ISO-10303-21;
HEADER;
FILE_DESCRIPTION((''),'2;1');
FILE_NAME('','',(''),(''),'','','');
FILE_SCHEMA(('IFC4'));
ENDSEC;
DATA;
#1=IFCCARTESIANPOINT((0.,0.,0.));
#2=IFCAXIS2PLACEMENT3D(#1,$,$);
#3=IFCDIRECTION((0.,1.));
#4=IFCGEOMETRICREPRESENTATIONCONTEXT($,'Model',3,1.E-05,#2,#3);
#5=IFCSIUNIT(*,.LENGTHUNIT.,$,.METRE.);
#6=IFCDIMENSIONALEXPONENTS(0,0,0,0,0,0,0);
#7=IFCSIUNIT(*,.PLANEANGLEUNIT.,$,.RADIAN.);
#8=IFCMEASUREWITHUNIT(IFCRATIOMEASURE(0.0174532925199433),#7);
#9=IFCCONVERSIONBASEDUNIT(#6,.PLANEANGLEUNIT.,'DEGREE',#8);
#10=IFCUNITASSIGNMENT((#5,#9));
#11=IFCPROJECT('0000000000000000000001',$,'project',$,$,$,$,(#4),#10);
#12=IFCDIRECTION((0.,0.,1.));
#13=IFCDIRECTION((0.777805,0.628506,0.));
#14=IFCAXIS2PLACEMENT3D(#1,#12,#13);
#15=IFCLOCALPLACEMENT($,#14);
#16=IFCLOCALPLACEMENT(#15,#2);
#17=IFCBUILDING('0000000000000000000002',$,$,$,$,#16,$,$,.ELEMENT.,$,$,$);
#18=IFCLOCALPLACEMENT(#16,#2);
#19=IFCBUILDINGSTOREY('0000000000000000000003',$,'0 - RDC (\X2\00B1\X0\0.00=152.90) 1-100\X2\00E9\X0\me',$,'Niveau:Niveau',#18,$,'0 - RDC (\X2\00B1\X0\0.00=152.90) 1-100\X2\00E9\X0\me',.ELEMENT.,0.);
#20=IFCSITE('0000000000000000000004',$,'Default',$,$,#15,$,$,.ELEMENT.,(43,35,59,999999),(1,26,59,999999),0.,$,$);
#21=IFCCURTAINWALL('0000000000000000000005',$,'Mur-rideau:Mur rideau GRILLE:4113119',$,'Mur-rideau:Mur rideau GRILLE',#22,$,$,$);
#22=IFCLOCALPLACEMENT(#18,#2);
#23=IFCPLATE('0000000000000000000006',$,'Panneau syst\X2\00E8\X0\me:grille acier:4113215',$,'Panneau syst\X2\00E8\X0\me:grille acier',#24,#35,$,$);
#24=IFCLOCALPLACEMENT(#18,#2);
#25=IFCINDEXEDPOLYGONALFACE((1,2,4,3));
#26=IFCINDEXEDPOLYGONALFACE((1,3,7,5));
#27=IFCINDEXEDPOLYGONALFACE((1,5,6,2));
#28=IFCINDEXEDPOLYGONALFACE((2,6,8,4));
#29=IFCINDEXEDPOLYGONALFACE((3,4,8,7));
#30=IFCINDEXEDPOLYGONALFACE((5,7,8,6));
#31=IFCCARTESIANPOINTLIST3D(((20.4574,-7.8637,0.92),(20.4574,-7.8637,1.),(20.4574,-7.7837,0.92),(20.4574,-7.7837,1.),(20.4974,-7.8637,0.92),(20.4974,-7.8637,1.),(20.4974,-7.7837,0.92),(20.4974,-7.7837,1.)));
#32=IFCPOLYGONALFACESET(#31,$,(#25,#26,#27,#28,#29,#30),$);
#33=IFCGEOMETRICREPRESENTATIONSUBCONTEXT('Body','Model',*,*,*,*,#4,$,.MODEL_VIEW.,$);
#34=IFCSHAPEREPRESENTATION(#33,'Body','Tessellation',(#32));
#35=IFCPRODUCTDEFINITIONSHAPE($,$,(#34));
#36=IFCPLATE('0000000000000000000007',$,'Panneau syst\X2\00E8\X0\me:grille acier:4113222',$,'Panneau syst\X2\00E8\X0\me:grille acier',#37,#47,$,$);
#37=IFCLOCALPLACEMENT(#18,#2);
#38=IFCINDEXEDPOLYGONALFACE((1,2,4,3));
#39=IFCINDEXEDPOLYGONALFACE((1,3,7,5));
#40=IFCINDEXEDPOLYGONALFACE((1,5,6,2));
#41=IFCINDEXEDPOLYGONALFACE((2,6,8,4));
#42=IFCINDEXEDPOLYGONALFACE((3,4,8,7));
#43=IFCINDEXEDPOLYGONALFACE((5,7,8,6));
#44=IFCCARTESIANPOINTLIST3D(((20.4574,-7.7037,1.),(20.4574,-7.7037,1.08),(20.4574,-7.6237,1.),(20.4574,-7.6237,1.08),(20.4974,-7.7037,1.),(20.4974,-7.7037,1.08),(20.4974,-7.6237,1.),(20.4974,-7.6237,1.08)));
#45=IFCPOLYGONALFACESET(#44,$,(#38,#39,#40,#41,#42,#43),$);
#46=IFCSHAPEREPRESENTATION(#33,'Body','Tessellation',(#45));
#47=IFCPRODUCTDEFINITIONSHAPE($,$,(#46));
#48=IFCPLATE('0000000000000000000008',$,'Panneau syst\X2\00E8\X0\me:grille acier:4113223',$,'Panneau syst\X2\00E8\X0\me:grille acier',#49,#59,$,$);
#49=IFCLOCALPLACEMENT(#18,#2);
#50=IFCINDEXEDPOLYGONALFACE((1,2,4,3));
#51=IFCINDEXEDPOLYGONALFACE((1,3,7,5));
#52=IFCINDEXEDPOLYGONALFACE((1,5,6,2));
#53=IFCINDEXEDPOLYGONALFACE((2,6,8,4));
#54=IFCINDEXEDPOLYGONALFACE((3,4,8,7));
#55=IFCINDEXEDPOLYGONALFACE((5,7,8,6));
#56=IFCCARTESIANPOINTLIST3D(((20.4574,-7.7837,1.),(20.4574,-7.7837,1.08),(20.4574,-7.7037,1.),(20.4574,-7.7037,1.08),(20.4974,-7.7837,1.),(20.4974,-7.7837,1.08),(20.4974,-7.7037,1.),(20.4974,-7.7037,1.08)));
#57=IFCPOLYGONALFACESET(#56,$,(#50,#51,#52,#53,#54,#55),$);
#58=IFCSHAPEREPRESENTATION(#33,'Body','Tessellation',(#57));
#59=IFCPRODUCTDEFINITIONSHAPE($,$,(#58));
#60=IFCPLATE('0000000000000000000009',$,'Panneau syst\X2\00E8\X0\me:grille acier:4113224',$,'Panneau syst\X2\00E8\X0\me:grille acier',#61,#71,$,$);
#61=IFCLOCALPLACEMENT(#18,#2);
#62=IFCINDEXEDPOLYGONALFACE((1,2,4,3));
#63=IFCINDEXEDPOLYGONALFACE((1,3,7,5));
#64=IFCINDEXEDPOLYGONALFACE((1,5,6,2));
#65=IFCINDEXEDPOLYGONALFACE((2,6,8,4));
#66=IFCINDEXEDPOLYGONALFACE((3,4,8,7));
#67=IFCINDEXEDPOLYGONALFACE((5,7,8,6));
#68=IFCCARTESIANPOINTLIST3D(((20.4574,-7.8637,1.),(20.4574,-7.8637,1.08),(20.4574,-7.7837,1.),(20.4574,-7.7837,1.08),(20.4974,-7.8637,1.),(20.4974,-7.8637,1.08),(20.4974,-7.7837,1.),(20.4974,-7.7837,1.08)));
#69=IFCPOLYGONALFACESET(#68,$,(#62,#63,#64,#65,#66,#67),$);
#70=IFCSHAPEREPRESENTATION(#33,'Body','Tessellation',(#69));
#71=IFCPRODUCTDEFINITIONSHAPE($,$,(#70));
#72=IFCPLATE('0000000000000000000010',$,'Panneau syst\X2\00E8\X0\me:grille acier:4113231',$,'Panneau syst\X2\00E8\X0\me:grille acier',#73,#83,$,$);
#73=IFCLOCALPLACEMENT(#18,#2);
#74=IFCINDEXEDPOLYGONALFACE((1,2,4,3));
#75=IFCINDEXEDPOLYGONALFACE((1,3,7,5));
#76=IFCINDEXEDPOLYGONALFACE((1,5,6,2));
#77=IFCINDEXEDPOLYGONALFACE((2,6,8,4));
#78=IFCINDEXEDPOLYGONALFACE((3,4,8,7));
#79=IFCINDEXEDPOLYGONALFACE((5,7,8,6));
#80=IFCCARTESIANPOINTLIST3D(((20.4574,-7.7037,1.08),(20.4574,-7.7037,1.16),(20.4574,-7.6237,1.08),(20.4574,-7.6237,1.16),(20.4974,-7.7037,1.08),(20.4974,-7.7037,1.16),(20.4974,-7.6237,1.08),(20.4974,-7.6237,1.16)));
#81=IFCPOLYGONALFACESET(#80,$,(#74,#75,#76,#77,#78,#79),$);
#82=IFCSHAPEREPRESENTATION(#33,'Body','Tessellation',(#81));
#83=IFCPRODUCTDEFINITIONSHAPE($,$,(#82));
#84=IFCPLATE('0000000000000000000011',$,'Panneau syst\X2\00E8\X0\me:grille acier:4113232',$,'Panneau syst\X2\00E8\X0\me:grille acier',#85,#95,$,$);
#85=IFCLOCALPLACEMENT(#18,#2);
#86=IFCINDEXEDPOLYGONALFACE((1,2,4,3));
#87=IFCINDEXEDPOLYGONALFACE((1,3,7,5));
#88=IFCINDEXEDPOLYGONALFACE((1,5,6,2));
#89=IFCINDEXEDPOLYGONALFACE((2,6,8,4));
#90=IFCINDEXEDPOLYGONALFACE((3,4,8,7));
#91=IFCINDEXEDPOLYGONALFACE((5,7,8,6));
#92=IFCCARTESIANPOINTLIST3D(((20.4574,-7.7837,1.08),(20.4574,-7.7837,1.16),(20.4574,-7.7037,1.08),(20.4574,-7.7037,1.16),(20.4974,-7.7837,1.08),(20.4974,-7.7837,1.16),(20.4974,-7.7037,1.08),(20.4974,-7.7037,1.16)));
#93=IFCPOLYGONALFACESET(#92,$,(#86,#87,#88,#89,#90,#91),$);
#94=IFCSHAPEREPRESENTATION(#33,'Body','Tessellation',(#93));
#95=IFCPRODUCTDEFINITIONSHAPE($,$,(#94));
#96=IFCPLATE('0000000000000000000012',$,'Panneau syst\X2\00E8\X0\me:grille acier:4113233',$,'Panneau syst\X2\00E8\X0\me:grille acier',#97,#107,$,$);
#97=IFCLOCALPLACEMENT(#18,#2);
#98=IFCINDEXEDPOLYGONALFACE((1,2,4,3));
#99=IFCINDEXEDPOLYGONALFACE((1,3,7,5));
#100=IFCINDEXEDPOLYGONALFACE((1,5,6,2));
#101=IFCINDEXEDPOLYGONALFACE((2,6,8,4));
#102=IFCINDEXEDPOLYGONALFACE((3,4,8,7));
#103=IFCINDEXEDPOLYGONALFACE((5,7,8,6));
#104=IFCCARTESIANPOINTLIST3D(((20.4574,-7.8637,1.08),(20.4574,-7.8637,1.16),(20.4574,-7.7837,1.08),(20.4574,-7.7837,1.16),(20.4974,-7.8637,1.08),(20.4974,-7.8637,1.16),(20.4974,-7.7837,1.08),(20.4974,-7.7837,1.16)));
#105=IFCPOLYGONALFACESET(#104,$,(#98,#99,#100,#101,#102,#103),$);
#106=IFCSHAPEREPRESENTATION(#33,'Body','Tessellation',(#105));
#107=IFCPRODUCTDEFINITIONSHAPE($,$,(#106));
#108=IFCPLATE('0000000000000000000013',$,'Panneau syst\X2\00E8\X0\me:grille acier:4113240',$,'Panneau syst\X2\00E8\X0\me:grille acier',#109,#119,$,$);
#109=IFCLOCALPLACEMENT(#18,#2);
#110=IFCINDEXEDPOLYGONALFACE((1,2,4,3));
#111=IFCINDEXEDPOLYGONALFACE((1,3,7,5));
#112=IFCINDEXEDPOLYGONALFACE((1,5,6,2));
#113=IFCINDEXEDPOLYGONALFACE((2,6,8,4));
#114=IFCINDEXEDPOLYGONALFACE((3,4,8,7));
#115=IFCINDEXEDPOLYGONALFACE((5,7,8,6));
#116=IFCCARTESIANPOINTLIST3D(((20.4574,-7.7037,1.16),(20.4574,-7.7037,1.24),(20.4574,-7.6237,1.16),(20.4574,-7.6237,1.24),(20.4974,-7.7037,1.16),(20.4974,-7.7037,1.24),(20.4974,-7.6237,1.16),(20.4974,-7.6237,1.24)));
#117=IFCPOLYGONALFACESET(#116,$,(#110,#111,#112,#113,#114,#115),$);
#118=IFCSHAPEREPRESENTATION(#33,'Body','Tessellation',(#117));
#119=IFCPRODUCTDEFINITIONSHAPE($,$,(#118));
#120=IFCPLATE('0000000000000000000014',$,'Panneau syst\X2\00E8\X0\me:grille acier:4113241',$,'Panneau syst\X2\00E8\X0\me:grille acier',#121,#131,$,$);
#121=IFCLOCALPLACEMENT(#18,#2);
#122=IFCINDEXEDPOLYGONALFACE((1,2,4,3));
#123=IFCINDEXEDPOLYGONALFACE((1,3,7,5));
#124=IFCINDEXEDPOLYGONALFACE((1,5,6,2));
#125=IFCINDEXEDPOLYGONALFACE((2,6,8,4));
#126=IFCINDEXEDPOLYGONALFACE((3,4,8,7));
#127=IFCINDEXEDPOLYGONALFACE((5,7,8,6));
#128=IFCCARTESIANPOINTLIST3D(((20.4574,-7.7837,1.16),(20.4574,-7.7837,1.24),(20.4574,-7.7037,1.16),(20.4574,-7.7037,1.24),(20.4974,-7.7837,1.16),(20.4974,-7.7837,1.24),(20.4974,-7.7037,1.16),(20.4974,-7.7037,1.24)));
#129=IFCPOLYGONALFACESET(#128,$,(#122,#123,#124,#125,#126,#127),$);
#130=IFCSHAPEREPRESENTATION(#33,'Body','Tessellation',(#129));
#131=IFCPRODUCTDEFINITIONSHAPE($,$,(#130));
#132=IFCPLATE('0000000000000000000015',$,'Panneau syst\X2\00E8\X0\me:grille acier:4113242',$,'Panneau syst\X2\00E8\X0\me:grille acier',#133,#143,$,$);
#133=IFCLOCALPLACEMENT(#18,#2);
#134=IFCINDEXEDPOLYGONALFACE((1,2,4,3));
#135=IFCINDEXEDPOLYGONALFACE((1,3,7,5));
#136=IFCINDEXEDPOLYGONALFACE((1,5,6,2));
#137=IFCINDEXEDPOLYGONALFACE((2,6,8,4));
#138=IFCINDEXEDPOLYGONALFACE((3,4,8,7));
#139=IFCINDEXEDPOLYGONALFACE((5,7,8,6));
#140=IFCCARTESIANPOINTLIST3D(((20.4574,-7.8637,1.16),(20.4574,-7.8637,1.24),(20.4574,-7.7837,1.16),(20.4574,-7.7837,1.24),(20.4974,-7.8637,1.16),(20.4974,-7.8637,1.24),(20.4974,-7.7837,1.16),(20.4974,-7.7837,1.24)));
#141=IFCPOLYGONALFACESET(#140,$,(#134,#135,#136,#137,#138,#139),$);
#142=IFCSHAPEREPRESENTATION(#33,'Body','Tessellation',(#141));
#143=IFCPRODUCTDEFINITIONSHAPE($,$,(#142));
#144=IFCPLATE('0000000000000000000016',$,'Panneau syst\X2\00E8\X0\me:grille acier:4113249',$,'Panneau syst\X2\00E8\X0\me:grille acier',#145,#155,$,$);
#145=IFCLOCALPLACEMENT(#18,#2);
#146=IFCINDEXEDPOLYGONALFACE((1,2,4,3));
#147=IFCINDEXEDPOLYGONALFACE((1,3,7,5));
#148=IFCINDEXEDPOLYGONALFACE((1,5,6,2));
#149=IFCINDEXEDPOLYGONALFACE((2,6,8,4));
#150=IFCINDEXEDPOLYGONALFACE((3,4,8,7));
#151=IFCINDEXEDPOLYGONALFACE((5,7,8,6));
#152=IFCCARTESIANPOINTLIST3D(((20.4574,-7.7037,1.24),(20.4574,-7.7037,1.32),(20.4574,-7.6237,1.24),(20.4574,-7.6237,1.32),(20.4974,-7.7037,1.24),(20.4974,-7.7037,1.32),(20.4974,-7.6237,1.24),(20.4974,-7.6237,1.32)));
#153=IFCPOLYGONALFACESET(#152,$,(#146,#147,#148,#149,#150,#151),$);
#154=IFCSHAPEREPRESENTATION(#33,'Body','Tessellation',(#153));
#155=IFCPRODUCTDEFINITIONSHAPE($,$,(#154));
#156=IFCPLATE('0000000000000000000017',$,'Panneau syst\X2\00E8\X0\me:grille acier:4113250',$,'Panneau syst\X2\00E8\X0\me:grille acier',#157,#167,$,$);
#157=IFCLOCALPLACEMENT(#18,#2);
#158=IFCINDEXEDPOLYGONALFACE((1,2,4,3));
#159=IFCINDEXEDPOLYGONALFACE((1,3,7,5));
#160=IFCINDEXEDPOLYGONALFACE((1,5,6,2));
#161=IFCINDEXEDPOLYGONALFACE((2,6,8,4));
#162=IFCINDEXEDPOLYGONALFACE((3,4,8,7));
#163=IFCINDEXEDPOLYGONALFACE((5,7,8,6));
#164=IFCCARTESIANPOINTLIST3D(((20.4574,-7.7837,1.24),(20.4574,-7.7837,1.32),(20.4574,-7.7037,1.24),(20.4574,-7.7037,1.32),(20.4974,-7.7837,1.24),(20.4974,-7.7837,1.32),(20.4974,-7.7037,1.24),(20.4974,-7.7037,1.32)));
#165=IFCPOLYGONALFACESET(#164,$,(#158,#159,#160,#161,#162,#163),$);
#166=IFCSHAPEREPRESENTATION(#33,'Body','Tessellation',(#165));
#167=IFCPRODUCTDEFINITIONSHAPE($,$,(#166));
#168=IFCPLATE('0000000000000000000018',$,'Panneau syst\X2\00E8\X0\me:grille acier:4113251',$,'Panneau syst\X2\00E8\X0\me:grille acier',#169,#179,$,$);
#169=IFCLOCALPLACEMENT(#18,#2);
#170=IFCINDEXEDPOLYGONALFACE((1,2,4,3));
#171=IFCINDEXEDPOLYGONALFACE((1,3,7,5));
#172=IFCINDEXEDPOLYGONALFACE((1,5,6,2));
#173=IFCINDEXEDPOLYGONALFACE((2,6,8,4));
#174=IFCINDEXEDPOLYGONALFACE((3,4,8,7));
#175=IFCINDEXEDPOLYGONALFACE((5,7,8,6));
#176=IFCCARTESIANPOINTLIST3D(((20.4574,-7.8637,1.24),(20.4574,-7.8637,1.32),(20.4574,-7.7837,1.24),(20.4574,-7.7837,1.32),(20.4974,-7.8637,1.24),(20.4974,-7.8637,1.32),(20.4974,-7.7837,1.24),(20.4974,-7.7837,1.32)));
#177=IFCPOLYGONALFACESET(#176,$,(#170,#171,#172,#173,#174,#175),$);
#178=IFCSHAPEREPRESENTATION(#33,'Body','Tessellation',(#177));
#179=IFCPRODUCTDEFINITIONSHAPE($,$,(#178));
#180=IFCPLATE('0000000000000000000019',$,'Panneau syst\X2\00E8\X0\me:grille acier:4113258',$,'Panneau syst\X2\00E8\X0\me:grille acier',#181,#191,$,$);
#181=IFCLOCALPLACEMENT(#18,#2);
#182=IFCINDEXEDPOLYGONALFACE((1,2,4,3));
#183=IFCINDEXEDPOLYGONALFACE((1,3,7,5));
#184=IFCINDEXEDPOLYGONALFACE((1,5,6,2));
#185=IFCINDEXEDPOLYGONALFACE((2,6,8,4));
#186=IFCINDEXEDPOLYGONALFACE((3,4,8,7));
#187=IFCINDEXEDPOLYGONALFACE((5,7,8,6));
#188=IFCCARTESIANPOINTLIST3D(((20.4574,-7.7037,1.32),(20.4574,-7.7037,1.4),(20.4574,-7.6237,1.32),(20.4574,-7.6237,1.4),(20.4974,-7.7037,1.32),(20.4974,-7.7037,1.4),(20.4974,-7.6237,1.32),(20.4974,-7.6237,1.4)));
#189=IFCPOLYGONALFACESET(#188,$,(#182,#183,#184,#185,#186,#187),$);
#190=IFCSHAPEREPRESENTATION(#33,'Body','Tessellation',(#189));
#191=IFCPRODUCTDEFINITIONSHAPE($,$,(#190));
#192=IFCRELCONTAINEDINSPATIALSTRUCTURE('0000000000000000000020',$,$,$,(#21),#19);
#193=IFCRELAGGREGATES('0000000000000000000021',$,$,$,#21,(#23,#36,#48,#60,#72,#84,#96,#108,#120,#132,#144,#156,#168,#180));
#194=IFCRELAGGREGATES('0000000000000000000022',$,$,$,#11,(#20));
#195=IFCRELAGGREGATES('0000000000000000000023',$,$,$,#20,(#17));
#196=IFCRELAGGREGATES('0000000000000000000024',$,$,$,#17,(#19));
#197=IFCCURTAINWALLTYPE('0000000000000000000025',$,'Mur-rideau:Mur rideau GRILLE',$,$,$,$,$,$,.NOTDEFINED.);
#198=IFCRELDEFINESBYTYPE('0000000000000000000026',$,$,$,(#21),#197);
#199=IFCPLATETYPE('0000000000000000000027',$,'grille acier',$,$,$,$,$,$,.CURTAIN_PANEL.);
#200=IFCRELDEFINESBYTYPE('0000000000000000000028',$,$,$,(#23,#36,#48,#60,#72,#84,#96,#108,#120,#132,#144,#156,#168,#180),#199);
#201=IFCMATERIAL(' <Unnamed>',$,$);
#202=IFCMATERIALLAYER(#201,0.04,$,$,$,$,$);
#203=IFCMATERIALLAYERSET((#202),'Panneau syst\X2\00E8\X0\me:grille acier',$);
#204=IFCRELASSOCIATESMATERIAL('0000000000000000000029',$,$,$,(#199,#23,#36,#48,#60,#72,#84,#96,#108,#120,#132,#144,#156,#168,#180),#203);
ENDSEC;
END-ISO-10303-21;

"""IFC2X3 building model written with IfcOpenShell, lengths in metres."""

from ifc_helpers import new_model, entity, si_unit, converted_unit, direction, frame, origin, origin_2d_with_axis, place, context, subcontext, project, spatial, rectangle, extrude, source, transform, mapped, material, layer, layer_set, layer_usage, type_object, type_shapes, element, aggregate, save


model = new_model("IFC2X3")

# Units and contexts
model_context = context("Model", 3, precision=1e-05, world=origin(), true_north=direction((0.0, 1.0)))
body_context = subcontext(model_context, "Body", "Model", "MODEL_VIEW")
ifc_project = project(units=[si_unit("LENGTHUNIT", "METRE"), converted_unit("PLANEANGLEUNIT", "DEGREE", entity("IfcRatioMeasure", 0.0174532925199433), si_unit("PLANEANGLEUNIT", "RADIAN"), dimensions=[0, 0, 0, 0, 0, 0, 0])], contexts=[model_context])

# Site, building, storey
site_placement = place(None, frame((0.0, 0.0, 0.0), z_axis=(0.0, 0.0, 1.0), x_axis=(0.777805, 0.628506, 0.0)))
site = spatial("IfcSite", under=ifc_project, at=site_placement, Name="Default", CompositionType="ELEMENT", RefLatitude=(43, 35, 59, 999999), RefLongitude=(1, 26, 59, 999999), RefElevation=0.0)
building_placement = place(site_placement, origin())
building = spatial("IfcBuilding", under=site, at=building_placement, CompositionType="ELEMENT")
storey_placement = place(building_placement, origin())
storey = spatial("IfcBuildingStorey", under=building, at=storey_placement, Name="0 - RDC (±0.00=152.90) 1-100éme", ObjectType="Niveau:Niveau", LongName="0 - RDC (±0.00=152.90) 1-100éme", CompositionType="ELEMENT", Elevation=0.0)

# Curtain wall, plates
curtain_wall_type = type_object("IfcCurtainWallType", Name="Mur-rideau:Mur rideau GRILLE", PredefinedType="NOTDEFINED")
curtain_wall_placement = place(storey_placement, origin())
curtain_wall = element("IfcCurtainWall", 1, at=curtain_wall_placement, inside=storey, type_object=curtain_wall_type, Name="Mur-rideau:Mur rideau GRILLE:4113119", ObjectType="Mur-rideau:Mur rideau GRILLE")
ifc_material = material(Name=" <Unnamed>")
ifc_layer = layer(ifc_material, 0.04)
ifc_layer_set = layer_set([ifc_layer], Name="Panneau système:grille acier")
ifc_layer_usage_1 = layer_usage(ifc_layer_set, "AXIS3", "POSITIVE", 0.0)
plate_type_1 = type_object("IfcPlateType", Name="grille acier", PredefinedType="CURTAIN_PANEL", material=ifc_layer_set)
shared_shape_1 = source(origin(), body_context, "Body", "SweptSolid", [
    extrude(rectangle(XDim=0.04, YDim=0.08, at=origin_2d_with_axis()), frame((0.0, 0.0, 0.0), z_axis=(0.0, 0.0, 1.0), x_axis=(0.0, 1.0, 0.0)), (0.0, 0.0, 1.0), 0.08),
])
type_shapes(plate_type_1, [shared_shape_1])
plate_1_placement = place(curtain_wall_placement, frame((20.4774, -7.8237, 0.92), z_axis=(0.0, 0.0, 1.0), x_axis=(0.0, -1.0, 0.0)))
plate_1 = element("IfcPlate", 2, at=plate_1_placement, type_object=plate_type_1, material=ifc_layer_usage_1, Name="Panneau système:grille acier:4113215", ObjectType="Panneau système:grille acier", context=body_context, shape_type="MappedRepresentation", body=[
    mapped(shared_shape_1, transform((0.0, 0.0, 0.0), scale=1.0)),
])
ifc_layer_usage_2 = layer_usage(ifc_layer_set, "AXIS3", "POSITIVE", 0.0)
plate_2_placement = place(curtain_wall_placement, frame((20.4774, -7.6637, 1.0), z_axis=(0.0, 0.0, 1.0), x_axis=(0.0, -1.0, 0.0)))
plate_2 = element("IfcPlate", 3, at=plate_2_placement, type_object=plate_type_1, material=ifc_layer_usage_2, Name="Panneau système:grille acier:4113222", ObjectType="Panneau système:grille acier", context=body_context, shape_type="MappedRepresentation", body=[
    mapped(shared_shape_1, transform((0.0, 0.0, 0.0), scale=1.0)),
])
ifc_layer_usage_3 = layer_usage(ifc_layer_set, "AXIS3", "POSITIVE", 0.0)
plate_3_placement = place(curtain_wall_placement, frame((20.4774, -7.7437, 1.0), z_axis=(0.0, 0.0, 1.0), x_axis=(0.0, -1.0, 0.0)))
plate_3 = element("IfcPlate", 4, at=plate_3_placement, type_object=plate_type_1, material=ifc_layer_usage_3, Name="Panneau système:grille acier:4113223", ObjectType="Panneau système:grille acier", context=body_context, shape_type="MappedRepresentation", body=[
    mapped(shared_shape_1, transform((0.0, 0.0, 0.0), scale=1.0)),
])
ifc_layer_usage_4 = layer_usage(ifc_layer_set, "AXIS3", "POSITIVE", 0.0)
plate_4_placement = place(curtain_wall_placement, frame((20.4774, -7.8237, 1.0), z_axis=(0.0, 0.0, 1.0), x_axis=(0.0, -1.0, 0.0)))
plate_4 = element("IfcPlate", 5, at=plate_4_placement, type_object=plate_type_1, material=ifc_layer_usage_4, Name="Panneau système:grille acier:4113224", ObjectType="Panneau système:grille acier", context=body_context, shape_type="MappedRepresentation", body=[
    mapped(shared_shape_1, transform((0.0, 0.0, 0.0), scale=1.0)),
])
ifc_layer_usage_5 = layer_usage(ifc_layer_set, "AXIS3", "POSITIVE", 0.0)
plate_5_placement = place(curtain_wall_placement, frame((20.4774, -7.6637, 1.08), z_axis=(0.0, 0.0, 1.0), x_axis=(0.0, -1.0, 0.0)))
plate_5 = element("IfcPlate", 6, at=plate_5_placement, type_object=plate_type_1, material=ifc_layer_usage_5, Name="Panneau système:grille acier:4113231", ObjectType="Panneau système:grille acier", context=body_context, shape_type="MappedRepresentation", body=[
    mapped(shared_shape_1, transform((0.0, 0.0, 0.0), scale=1.0)),
])
ifc_layer_usage_6 = layer_usage(ifc_layer_set, "AXIS3", "POSITIVE", 0.0)
plate_6_placement = place(curtain_wall_placement, frame((20.4774, -7.7437, 1.08), z_axis=(0.0, 0.0, 1.0), x_axis=(0.0, -1.0, 0.0)))
plate_6 = element("IfcPlate", 7, at=plate_6_placement, type_object=plate_type_1, material=ifc_layer_usage_6, Name="Panneau système:grille acier:4113232", ObjectType="Panneau système:grille acier", context=body_context, shape_type="MappedRepresentation", body=[
    mapped(shared_shape_1, transform((0.0, 0.0, 0.0), scale=1.0)),
])
ifc_layer_usage_7 = layer_usage(ifc_layer_set, "AXIS3", "POSITIVE", 0.0)
plate_7_placement = place(curtain_wall_placement, frame((20.4774, -7.8237, 1.08), z_axis=(0.0, 0.0, 1.0), x_axis=(0.0, -1.0, 0.0)))
plate_7 = element("IfcPlate", 8, at=plate_7_placement, type_object=plate_type_1, material=ifc_layer_usage_7, Name="Panneau système:grille acier:4113233", ObjectType="Panneau système:grille acier", context=body_context, shape_type="MappedRepresentation", body=[
    mapped(shared_shape_1, transform((0.0, 0.0, 0.0), scale=1.0)),
])
ifc_layer_usage_8 = layer_usage(ifc_layer_set, "AXIS3", "POSITIVE", 0.0)
plate_8_placement = place(curtain_wall_placement, frame((20.4774, -7.6637, 1.16), z_axis=(0.0, 0.0, 1.0), x_axis=(0.0, -1.0, 0.0)))
plate_8 = element("IfcPlate", 9, at=plate_8_placement, type_object=plate_type_1, material=ifc_layer_usage_8, Name="Panneau système:grille acier:4113240", ObjectType="Panneau système:grille acier", context=body_context, shape_type="MappedRepresentation", body=[
    mapped(shared_shape_1, transform((0.0, 0.0, 0.0), scale=1.0)),
])
ifc_layer_usage_9 = layer_usage(ifc_layer_set, "AXIS3", "POSITIVE", 0.0)
plate_9_placement = place(curtain_wall_placement, frame((20.4774, -7.7437, 1.16), z_axis=(0.0, 0.0, 1.0), x_axis=(0.0, -1.0, 0.0)))
plate_9 = element("IfcPlate", 10, at=plate_9_placement, type_object=plate_type_1, material=ifc_layer_usage_9, Name="Panneau système:grille acier:4113241", ObjectType="Panneau système:grille acier", context=body_context, shape_type="MappedRepresentation", body=[
    mapped(shared_shape_1, transform((0.0, 0.0, 0.0), scale=1.0)),
])
ifc_layer_usage_10 = layer_usage(ifc_layer_set, "AXIS3", "POSITIVE", 0.0)
plate_10_placement = place(curtain_wall_placement, frame((20.4774, -7.8237, 1.16), z_axis=(0.0, 0.0, 1.0), x_axis=(0.0, -1.0, 0.0)))
plate_10 = element("IfcPlate", 11, at=plate_10_placement, type_object=plate_type_1, material=ifc_layer_usage_10, Name="Panneau système:grille acier:4113242", ObjectType="Panneau système:grille acier", context=body_context, shape_type="MappedRepresentation", body=[
    mapped(shared_shape_1, transform((0.0, 0.0, 0.0), scale=1.0)),
])
ifc_layer_usage_11 = layer_usage(ifc_layer_set, "AXIS3", "POSITIVE", 0.0)
plate_11_placement = place(curtain_wall_placement, frame((20.4774, -7.6637, 1.24), z_axis=(0.0, 0.0, 1.0), x_axis=(0.0, -1.0, 0.0)))
plate_11 = element("IfcPlate", 12, at=plate_11_placement, type_object=plate_type_1, material=ifc_layer_usage_11, Name="Panneau système:grille acier:4113249", ObjectType="Panneau système:grille acier", context=body_context, shape_type="MappedRepresentation", body=[
    mapped(shared_shape_1, transform((0.0, 0.0, 0.0), scale=1.0)),
])
ifc_layer_usage_12 = layer_usage(ifc_layer_set, "AXIS3", "POSITIVE", 0.0)
plate_12_placement = place(curtain_wall_placement, frame((20.4774, -7.7437, 1.24), z_axis=(0.0, 0.0, 1.0), x_axis=(0.0, -1.0, 0.0)))
plate_12 = element("IfcPlate", 13, at=plate_12_placement, type_object=plate_type_1, material=ifc_layer_usage_12, Name="Panneau système:grille acier:4113250", ObjectType="Panneau système:grille acier", context=body_context, shape_type="MappedRepresentation", body=[
    mapped(shared_shape_1, transform((0.0, 0.0, 0.0), scale=1.0)),
])
ifc_layer_usage_13 = layer_usage(ifc_layer_set, "AXIS3", "POSITIVE", 0.0)
plate_13_placement = place(curtain_wall_placement, frame((20.4774, -7.8237, 1.24), z_axis=(0.0, 0.0, 1.0), x_axis=(0.0, -1.0, 0.0)))
plate_13 = element("IfcPlate", 14, at=plate_13_placement, type_object=plate_type_1, material=ifc_layer_usage_13, Name="Panneau système:grille acier:4113251", ObjectType="Panneau système:grille acier", context=body_context, shape_type="MappedRepresentation", body=[
    mapped(shared_shape_1, transform((0.0, 0.0, 0.0), scale=1.0)),
])
ifc_layer_usage_14 = layer_usage(ifc_layer_set, "AXIS3", "POSITIVE", 0.0)
plate_14_placement = place(curtain_wall_placement, frame((20.4774, -7.6637, 1.32), z_axis=(0.0, 0.0, 1.0), x_axis=(0.0, -1.0, 0.0)))
plate_14 = element("IfcPlate", 15, at=plate_14_placement, type_object=plate_type_1, material=ifc_layer_usage_14, Name="Panneau système:grille acier:4113258", ObjectType="Panneau système:grille acier", context=body_context, shape_type="MappedRepresentation", body=[
    mapped(shared_shape_1, transform((0.0, 0.0, 0.0), scale=1.0)),
])
aggregate(curtain_wall, [plate_1, plate_2, plate_3, plate_4, plate_5, plate_6, plate_7, plate_8, plate_9, plate_10, plate_11, plate_12, plate_13, plate_14])

save(model, "model.ifc")
